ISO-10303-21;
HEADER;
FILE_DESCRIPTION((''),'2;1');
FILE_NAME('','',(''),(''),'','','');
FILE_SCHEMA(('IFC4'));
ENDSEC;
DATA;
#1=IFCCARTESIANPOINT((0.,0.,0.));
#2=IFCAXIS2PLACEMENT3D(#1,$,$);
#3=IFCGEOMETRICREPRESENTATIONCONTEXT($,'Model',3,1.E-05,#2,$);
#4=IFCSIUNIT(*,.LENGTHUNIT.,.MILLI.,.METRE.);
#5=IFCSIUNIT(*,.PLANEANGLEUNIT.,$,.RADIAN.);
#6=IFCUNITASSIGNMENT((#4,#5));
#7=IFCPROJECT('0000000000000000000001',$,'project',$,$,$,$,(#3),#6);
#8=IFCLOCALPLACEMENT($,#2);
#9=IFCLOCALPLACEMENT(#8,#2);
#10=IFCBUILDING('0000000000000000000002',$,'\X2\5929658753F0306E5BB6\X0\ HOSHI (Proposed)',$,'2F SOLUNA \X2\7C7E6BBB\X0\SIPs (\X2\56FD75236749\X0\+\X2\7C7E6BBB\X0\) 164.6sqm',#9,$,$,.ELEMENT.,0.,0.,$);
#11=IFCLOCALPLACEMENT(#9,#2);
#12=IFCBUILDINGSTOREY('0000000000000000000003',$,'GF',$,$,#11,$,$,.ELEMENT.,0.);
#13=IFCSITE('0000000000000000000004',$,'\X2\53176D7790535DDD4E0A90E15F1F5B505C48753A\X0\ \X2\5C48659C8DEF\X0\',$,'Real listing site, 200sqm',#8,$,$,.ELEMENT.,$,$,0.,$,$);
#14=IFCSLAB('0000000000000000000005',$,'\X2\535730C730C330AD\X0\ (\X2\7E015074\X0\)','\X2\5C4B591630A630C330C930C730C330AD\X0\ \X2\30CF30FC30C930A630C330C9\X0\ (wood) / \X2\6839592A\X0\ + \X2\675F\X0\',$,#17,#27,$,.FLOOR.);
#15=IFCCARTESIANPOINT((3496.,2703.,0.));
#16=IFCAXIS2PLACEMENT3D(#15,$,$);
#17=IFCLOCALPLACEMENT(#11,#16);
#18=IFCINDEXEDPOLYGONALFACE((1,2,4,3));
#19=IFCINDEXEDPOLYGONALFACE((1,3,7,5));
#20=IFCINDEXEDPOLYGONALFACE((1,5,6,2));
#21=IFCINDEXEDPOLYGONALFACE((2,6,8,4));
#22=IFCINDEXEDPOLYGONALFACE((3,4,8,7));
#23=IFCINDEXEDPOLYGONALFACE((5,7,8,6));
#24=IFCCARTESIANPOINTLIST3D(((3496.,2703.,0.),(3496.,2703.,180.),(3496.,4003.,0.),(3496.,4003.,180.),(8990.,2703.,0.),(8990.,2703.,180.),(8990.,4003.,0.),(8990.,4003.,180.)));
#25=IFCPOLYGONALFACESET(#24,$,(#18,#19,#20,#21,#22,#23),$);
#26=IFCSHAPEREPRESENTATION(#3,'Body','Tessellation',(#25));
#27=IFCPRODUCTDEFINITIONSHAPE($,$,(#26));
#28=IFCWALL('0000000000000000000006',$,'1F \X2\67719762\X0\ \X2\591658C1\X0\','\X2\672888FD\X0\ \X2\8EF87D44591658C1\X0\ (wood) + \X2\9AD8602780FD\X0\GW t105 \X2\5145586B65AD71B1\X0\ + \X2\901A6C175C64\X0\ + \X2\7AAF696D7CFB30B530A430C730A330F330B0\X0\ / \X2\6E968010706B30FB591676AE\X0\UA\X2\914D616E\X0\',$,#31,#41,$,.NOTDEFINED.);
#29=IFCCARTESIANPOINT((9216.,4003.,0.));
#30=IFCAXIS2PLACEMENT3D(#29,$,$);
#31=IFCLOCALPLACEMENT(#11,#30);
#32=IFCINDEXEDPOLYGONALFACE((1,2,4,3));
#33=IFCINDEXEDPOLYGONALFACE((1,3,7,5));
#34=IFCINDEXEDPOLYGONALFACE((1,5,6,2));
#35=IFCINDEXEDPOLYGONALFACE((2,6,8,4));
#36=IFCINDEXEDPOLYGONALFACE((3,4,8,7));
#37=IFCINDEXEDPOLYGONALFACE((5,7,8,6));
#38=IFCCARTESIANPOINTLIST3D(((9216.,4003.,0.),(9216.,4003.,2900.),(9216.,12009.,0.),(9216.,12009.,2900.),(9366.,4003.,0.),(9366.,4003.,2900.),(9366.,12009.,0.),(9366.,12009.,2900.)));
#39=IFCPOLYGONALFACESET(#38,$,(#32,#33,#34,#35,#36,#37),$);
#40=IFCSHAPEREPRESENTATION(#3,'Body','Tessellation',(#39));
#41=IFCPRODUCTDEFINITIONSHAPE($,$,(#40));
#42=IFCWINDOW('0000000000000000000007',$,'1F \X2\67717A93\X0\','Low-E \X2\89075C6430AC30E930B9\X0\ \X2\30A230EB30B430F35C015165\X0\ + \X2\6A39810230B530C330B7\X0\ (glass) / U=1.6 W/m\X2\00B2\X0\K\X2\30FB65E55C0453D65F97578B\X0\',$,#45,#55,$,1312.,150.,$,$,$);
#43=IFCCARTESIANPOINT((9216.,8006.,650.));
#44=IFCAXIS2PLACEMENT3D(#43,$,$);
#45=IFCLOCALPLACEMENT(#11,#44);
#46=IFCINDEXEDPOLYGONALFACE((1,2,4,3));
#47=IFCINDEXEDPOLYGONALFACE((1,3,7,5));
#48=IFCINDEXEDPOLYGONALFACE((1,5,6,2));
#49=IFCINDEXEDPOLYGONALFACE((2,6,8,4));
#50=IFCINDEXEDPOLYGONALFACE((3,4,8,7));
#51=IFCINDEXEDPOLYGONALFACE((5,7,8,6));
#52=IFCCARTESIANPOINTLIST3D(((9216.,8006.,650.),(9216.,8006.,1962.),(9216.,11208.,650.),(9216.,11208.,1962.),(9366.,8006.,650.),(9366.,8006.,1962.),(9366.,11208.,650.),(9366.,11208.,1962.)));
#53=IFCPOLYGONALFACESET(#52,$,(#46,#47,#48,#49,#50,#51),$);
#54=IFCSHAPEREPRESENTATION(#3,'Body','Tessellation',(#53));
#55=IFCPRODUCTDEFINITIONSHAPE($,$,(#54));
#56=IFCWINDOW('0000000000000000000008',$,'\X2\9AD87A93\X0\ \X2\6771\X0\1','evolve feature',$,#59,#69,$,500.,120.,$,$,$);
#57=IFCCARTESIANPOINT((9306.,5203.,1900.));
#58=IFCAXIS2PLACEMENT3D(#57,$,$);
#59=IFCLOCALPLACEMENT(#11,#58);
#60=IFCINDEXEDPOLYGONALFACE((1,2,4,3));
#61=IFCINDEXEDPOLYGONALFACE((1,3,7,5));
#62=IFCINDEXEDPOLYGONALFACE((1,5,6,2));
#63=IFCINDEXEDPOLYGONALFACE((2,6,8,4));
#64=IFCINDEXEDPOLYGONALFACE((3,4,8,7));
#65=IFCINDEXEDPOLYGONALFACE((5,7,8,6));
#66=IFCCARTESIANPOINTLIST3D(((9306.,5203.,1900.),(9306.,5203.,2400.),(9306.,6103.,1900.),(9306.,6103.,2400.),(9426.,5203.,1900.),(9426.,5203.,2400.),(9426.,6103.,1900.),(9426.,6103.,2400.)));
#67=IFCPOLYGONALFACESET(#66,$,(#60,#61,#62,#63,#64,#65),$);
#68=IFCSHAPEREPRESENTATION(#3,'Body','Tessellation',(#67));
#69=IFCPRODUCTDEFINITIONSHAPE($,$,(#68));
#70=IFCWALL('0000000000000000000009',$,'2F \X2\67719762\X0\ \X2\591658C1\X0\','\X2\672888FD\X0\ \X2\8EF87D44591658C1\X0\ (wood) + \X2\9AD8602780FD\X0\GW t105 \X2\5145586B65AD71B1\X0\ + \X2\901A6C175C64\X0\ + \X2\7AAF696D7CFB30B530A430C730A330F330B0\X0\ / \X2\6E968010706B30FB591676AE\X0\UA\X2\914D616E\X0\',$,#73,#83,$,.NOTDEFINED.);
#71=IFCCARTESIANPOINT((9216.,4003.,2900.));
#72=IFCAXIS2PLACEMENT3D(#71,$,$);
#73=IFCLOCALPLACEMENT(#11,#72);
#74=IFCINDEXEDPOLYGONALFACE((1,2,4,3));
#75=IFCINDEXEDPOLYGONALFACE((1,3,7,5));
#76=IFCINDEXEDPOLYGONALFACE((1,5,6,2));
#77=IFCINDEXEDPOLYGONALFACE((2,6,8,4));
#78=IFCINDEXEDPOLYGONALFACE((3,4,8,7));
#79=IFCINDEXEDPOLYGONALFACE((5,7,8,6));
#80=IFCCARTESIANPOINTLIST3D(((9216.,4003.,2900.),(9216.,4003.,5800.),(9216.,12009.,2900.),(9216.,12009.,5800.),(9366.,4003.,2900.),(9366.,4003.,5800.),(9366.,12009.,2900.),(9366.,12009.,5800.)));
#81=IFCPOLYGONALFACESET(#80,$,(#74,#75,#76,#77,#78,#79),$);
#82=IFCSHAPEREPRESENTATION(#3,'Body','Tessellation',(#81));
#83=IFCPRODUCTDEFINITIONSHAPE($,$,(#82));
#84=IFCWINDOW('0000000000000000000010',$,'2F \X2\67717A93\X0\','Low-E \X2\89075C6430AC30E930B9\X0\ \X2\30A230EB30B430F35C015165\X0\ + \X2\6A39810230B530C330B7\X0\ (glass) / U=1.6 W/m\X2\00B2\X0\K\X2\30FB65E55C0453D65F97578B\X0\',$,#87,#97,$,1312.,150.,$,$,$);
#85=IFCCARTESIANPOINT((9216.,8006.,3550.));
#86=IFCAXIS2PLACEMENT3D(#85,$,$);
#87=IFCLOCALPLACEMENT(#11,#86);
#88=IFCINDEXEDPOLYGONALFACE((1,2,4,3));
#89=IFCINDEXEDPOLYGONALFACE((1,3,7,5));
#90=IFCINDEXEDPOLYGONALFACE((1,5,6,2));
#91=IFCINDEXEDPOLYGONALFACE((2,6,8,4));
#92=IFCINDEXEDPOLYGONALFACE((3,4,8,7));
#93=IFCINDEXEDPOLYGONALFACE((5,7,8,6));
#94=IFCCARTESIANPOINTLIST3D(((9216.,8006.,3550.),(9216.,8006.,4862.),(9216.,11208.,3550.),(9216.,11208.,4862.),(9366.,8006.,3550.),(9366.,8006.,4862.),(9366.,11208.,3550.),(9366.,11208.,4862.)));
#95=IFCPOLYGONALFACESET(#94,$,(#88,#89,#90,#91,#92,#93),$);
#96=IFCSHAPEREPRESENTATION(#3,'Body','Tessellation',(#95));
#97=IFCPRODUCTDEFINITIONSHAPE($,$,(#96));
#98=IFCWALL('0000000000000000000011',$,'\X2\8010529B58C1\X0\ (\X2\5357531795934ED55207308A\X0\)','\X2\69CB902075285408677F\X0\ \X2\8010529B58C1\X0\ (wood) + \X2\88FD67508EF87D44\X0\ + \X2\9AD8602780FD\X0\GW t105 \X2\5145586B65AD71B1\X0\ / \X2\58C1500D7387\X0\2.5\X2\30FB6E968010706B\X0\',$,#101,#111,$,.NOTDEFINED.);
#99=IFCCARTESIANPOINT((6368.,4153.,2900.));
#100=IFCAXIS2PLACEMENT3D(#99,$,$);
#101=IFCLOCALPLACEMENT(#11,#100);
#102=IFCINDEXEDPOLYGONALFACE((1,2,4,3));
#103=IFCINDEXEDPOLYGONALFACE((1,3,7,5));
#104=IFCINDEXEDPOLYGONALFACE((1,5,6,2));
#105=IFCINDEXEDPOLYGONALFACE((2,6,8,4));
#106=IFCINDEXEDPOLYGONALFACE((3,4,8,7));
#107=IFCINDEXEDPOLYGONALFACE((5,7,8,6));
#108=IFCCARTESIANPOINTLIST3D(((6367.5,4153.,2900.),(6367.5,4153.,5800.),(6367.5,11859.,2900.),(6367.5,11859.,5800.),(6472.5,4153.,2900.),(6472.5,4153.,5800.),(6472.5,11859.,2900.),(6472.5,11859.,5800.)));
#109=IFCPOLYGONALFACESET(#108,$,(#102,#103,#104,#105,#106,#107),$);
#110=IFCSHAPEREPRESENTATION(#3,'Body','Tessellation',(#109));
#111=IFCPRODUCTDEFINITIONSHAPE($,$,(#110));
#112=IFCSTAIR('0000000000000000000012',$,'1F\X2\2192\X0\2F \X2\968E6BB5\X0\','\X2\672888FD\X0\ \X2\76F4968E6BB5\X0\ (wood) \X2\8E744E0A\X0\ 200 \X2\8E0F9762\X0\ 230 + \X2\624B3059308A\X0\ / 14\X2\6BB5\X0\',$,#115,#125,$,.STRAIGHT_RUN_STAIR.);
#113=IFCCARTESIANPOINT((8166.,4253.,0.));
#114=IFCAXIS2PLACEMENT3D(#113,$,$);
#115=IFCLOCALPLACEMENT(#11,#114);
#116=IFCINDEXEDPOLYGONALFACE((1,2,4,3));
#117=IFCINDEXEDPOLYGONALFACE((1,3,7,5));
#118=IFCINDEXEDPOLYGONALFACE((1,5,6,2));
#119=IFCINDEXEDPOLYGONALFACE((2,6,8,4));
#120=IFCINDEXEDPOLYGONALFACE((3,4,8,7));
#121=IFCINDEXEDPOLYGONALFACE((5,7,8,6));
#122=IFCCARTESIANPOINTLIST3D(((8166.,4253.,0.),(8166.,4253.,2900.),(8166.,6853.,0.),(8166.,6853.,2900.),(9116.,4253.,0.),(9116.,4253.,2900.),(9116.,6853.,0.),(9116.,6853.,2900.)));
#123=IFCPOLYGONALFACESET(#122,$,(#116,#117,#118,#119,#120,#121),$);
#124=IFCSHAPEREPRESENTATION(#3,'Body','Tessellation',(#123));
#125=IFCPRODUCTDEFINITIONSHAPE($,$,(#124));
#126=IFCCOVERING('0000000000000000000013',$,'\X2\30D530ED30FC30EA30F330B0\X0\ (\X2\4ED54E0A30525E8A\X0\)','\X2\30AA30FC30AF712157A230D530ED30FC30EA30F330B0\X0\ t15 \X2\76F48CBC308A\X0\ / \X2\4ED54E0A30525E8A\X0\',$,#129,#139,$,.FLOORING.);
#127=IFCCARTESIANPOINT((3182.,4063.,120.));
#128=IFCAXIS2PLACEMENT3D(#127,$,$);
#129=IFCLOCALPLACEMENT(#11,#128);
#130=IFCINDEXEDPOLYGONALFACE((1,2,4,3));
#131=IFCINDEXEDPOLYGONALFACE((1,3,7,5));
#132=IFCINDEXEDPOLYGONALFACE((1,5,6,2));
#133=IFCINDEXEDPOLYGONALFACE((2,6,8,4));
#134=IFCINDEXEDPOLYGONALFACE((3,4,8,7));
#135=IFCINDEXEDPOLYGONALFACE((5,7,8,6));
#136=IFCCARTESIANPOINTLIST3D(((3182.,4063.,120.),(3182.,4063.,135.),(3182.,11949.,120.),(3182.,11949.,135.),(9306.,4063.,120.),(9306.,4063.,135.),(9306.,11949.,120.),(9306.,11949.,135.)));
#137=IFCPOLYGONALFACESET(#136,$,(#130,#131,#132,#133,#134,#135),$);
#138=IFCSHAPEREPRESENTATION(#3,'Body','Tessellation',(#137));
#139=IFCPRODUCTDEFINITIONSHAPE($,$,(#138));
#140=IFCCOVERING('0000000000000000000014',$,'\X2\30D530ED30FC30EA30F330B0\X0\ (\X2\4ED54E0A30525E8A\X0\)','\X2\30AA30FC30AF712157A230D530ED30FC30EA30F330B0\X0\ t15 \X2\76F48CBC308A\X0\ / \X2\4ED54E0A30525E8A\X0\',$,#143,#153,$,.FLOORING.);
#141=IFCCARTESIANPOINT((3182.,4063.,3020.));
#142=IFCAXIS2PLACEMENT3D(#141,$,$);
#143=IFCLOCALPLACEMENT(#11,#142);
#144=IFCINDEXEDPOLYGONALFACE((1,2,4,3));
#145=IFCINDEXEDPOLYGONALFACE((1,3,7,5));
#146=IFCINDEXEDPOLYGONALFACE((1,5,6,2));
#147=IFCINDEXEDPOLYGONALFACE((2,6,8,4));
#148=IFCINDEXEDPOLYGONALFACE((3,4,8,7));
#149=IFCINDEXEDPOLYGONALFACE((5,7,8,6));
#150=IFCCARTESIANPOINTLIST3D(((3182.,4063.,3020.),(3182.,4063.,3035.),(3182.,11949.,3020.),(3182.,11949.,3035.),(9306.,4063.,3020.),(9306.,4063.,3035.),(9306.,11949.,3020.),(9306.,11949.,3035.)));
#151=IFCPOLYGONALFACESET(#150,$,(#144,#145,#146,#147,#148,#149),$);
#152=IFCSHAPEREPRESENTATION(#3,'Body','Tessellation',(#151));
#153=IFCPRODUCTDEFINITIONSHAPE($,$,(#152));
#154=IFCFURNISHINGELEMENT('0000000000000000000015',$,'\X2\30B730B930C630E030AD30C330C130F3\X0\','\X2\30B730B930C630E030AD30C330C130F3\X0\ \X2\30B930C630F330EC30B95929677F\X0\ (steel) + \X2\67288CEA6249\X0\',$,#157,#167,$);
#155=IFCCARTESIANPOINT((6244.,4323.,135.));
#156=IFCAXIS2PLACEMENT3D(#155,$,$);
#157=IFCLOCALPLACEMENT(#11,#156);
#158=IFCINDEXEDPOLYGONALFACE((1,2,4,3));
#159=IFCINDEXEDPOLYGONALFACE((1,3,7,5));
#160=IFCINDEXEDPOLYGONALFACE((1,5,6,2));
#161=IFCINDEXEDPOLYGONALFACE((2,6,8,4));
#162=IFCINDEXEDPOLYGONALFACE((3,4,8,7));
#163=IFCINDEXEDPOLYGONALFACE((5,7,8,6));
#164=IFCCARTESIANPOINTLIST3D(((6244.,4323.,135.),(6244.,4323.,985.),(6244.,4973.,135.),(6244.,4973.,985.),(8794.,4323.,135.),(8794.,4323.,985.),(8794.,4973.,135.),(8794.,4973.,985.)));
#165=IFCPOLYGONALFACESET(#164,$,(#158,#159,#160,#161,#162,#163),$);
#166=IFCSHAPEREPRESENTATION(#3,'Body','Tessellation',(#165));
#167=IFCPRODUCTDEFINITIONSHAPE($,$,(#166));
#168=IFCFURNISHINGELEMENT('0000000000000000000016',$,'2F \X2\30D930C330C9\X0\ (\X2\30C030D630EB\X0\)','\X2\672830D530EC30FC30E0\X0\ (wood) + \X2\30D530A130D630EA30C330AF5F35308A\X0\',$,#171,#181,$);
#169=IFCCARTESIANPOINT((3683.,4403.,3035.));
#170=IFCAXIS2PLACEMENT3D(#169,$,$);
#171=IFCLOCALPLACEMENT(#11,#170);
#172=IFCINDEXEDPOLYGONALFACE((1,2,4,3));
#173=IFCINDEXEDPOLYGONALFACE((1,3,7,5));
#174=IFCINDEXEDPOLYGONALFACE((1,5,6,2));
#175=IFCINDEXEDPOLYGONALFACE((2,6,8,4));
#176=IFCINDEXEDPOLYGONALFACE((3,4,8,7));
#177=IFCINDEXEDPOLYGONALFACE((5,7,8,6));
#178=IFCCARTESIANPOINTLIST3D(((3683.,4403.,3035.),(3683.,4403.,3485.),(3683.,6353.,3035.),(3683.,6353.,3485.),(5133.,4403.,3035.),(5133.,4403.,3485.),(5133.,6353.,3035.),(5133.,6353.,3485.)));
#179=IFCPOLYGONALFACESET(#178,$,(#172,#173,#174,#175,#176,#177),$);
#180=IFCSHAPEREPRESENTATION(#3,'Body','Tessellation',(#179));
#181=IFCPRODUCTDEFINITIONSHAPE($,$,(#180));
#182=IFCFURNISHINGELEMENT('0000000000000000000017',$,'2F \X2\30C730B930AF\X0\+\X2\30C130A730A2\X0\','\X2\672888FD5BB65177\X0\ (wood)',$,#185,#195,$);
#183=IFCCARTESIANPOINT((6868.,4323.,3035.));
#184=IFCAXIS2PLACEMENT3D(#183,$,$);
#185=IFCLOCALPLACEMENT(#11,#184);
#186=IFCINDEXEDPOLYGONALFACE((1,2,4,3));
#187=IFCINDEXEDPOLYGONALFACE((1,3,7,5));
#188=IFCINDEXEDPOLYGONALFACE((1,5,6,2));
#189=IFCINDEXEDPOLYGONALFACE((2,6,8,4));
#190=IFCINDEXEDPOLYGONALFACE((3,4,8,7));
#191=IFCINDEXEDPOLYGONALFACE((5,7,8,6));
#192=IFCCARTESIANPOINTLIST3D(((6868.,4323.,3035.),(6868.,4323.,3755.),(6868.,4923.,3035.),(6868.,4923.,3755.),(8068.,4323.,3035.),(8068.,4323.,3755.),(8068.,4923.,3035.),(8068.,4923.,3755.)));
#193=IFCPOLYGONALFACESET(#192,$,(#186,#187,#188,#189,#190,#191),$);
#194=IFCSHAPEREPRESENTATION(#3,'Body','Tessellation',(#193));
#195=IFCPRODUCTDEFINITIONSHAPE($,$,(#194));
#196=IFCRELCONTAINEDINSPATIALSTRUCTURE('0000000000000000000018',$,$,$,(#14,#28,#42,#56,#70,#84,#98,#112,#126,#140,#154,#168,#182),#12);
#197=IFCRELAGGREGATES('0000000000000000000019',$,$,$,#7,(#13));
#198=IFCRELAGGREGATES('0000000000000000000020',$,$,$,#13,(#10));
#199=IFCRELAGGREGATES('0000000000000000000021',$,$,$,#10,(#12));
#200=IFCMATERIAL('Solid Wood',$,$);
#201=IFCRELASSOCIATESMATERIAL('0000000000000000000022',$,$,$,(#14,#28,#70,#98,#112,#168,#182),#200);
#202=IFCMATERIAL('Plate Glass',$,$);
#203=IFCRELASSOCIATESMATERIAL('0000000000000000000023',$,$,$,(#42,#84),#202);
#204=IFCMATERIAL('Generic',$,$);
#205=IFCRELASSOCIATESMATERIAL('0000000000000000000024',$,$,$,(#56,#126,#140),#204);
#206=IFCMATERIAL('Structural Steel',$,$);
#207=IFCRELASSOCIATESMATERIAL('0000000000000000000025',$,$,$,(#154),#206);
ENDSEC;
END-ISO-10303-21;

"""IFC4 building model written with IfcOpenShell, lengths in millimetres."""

from ifc_helpers import new_model, si_unit, frame, frame_2d, origin, place, context, project, spatial, rectangle, extrude, material, element, fill, save


model = new_model("IFC4")

# Units and contexts
model_context = context("Model", 3, precision=1e-05, world=origin())
ifc_project = project(units=[si_unit("LENGTHUNIT", "METRE", prefix="MILLI"), si_unit("PLANEANGLEUNIT", "RADIAN")], contexts=[model_context])

# Site, building, storey
site_placement = place(None, origin())
site = spatial("IfcSite", under=ifc_project, at=site_placement, Name="北海道川上郡弟子屈町 屈斜路", ObjectType="Real listing site, 200sqm", CompositionType="ELEMENT", RefElevation=0.0)
building_placement = place(site_placement, origin())
building = spatial("IfcBuilding", under=site, at=building_placement, Name="天文台の家 HOSHI (Proposed)", ObjectType="2F SOLUNA 籾殻SIPs (国産杉+籾殻) 164.6sqm", CompositionType="ELEMENT", ElevationOfRefHeight=0.0, ElevationOfTerrain=0.0)
storey_placement = place(building_placement, origin())
storey = spatial("IfcBuildingStorey", under=building, at=storey_placement, Name="GF", CompositionType="ELEMENT", Elevation=0.0)

# Slab
ifc_material_1 = material(Name="Solid Wood")
slab_placement = place(storey_placement, frame((3496.0, 2703.0, 0.0)))
element("IfcSlab", 1, at=slab_placement, inside=storey, material=ifc_material_1, Name="南デッキ (縁側)", Description="屋外ウッドデッキ ハードウッド (wood) / 根太 + 束", PredefinedType="FLOOR", context=model_context, shape_type="SweptSolid", body=[
    extrude(rectangle(XDim=5494.0, YDim=1300.0, at=frame_2d((2747.0, 650.0))), frame((3496.0, 2703.0, 0.0)), (0.0, 0.0, 1.0), 180.0),
])

# Wall, openings, windows
wall_1_placement = place(storey_placement, frame((9216.0, 4003.0, 0.0)))
wall_1 = element("IfcWall", 2, at=wall_1_placement, inside=storey, material=ifc_material_1, Name="1F 東面 外壁", Description="木製 軸組外壁 (wood) + 高性能GW t105 充填断熱 + 通気層 + 窯業系サイディング / 準耐火・外皮UA配慮", PredefinedType="NOTDEFINED", context=model_context, shape_type="SweptSolid", body=[
    extrude(rectangle(XDim=150.0, YDim=8006.0, at=frame_2d((75.0, 4003.0))), frame((9216.0, 4003.0, 0.0)), (0.0, 0.0, 1.0), 2900.0),
])
opening_1_placement = place(storey_placement, frame((9216.0, 8006.0, 650.0)))
opening_1 = element("IfcOpeningElement", 3, at=opening_1_placement, cuts=wall_1, PredefinedType="NOTDEFINED", context=model_context, shape_type="SweptSolid", body=[
    extrude(rectangle(XDim=150.0, YDim=3202.0, at=frame_2d((75.0, 1601.0))), frame((9216.0, 8006.0, 650.0)), (0.0, 0.0, 1.0), 1312.0),
])
opening_2_placement = place(storey_placement, frame((9306.0, 5203.0, 1900.0)))
opening_2 = element("IfcOpeningElement", 4, at=opening_2_placement, cuts=wall_1, PredefinedType="NOTDEFINED", context=model_context, shape_type="SweptSolid", body=[
    extrude(rectangle(XDim=120.0, YDim=900.0, at=frame_2d((60.0, 450.0))), frame((9306.0, 5203.0, 1900.0)), (0.0, 0.0, 1.0), 500.0),
])
ifc_material_2 = material(Name="Plate Glass")
window_1_placement = place(storey_placement, frame((9216.0, 8006.0, 650.0)))
window_1 = element("IfcWindow", 5, at=window_1_placement, inside=storey, material=ifc_material_2, Name="1F 東窓", Description="Low-E 複層ガラス アルゴン封入 + 樹脂サッシ (glass) / U=1.6 W/m²K・日射取得型", OverallHeight=1312.0, OverallWidth=150.0, context=model_context, shape_type="SweptSolid", body=[
    extrude(rectangle(XDim=150.0, YDim=3202.0, at=frame_2d((75.0, 1601.0))), frame((9216.0, 8006.0, 650.0)), (0.0, 0.0, 1.0), 1312.0),
])
fill(opening_1, window_1)
ifc_material_3 = material(Name="Generic")
window_2_placement = place(storey_placement, frame((9306.0, 5203.0, 1900.0)))
window_2 = element("IfcWindow", 6, at=window_2_placement, inside=storey, material=ifc_material_3, Name="高窓 東1", Description="evolve feature", OverallHeight=500.0, OverallWidth=120.0, context=model_context, shape_type="SweptSolid", body=[
    extrude(rectangle(XDim=120.0, YDim=900.0, at=frame_2d((60.0, 450.0))), frame((9306.0, 5203.0, 1900.0)), (0.0, 0.0, 1.0), 500.0),
])
fill(opening_2, window_2)

# Wall, opening, window
wall_2_placement = place(storey_placement, frame((9216.0, 4003.0, 2900.0)))
wall_2 = element("IfcWall", 7, at=wall_2_placement, inside=storey, material=ifc_material_1, Name="2F 東面 外壁", Description="木製 軸組外壁 (wood) + 高性能GW t105 充填断熱 + 通気層 + 窯業系サイディング / 準耐火・外皮UA配慮", PredefinedType="NOTDEFINED", context=model_context, shape_type="SweptSolid", body=[
    extrude(rectangle(XDim=150.0, YDim=8006.0, at=frame_2d((75.0, 4003.0))), frame((9216.0, 4003.0, 2900.0)), (0.0, 0.0, 1.0), 2900.0),
])
opening_3_placement = place(storey_placement, frame((9216.0, 8006.0, 3550.0)))
opening_3 = element("IfcOpeningElement", 8, at=opening_3_placement, cuts=wall_2, PredefinedType="NOTDEFINED", context=model_context, shape_type="SweptSolid", body=[
    extrude(rectangle(XDim=150.0, YDim=3202.0, at=frame_2d((75.0, 1601.0))), frame((9216.0, 8006.0, 3550.0)), (0.0, 0.0, 1.0), 1312.0),
])
window_3_placement = place(storey_placement, frame((9216.0, 8006.0, 3550.0)))
window_3 = element("IfcWindow", 9, at=window_3_placement, inside=storey, material=ifc_material_2, Name="2F 東窓", Description="Low-E 複層ガラス アルゴン封入 + 樹脂サッシ (glass) / U=1.6 W/m²K・日射取得型", OverallHeight=1312.0, OverallWidth=150.0, context=model_context, shape_type="SweptSolid", body=[
    extrude(rectangle(XDim=150.0, YDim=3202.0, at=frame_2d((75.0, 1601.0))), frame((9216.0, 8006.0, 3550.0)), (0.0, 0.0, 1.0), 1312.0),
])
fill(opening_3, window_3)

# Wall
wall_3_placement = place(storey_placement, frame((6368.0, 4153.0, 2900.0)))
element("IfcWall", 10, at=wall_3_placement, inside=storey, material=ifc_material_1, Name="耐力壁 (南北間仕切り)", Description="構造用合板 耐力壁 (wood) + 製材軸組 + 高性能GW t105 充填断熱 / 壁倍率2.5・準耐火", PredefinedType="NOTDEFINED", context=model_context, shape_type="SweptSolid", body=[
    extrude(rectangle(XDim=105.0, YDim=7706.0, at=frame_2d((52.0, 3853.0))), frame((6368.0, 4153.0, 2900.0)), (0.0, 0.0, 1.0), 2900.0),
])

# Stair
stair_placement = place(storey_placement, frame((8166.0, 4253.0, 0.0)))
element("IfcStair", 11, at=stair_placement, inside=storey, material=ifc_material_1, Name="1F→2F 階段", Description="木製 直階段 (wood) 蹴上 200 踏面 230 + 手すり / 14段", PredefinedType="STRAIGHT_RUN_STAIR", context=model_context, shape_type="SweptSolid", body=[
    extrude(rectangle(XDim=950.0, YDim=2600.0, at=frame_2d((475.0, 1300.0))), frame((8166.0, 4253.0, 0.0)), (0.0, 0.0, 1.0), 2900.0),
])

# Coverings
covering_1_placement = place(storey_placement, frame((3182.0, 4063.0, 120.0)))
element("IfcCovering", 12, at=covering_1_placement, inside=storey, material=ifc_material_3, Name="フローリング (仕上げ床)", Description="オーク無垢フローリング t15 直貼り / 仕上げ床", PredefinedType="FLOORING", context=model_context, shape_type="SweptSolid", body=[
    extrude(rectangle(XDim=6124.0, YDim=7886.0, at=frame_2d((3062.0, 3943.0))), frame((3182.0, 4063.0, 120.0)), (0.0, 0.0, 1.0), 15.0),
])
covering_2_placement = place(storey_placement, frame((3182.0, 4063.0, 3020.0)))
element("IfcCovering", 13, at=covering_2_placement, inside=storey, material=ifc_material_3, Name="フローリング (仕上げ床)", Description="オーク無垢フローリング t15 直貼り / 仕上げ床", PredefinedType="FLOORING", context=model_context, shape_type="SweptSolid", body=[
    extrude(rectangle(XDim=6124.0, YDim=7886.0, at=frame_2d((3062.0, 3943.0))), frame((3182.0, 4063.0, 3020.0)), (0.0, 0.0, 1.0), 15.0),
])

# Furnishing elements
ifc_material_4 = material(Name="Structural Steel")
furnishing_1_placement = place(storey_placement, frame((6244.0, 4323.0, 135.0)))
element("IfcFurnishingElement", 14, at=furnishing_1_placement, inside=storey, material=ifc_material_4, Name="システムキッチン", Description="システムキッチン ステンレス天板 (steel) + 木質扉", context=model_context, shape_type="SweptSolid", body=[
    extrude(rectangle(XDim=2550.0, YDim=650.0, at=frame_2d((1275.0, 325.0))), frame((6244.0, 4323.0, 135.0)), (0.0, 0.0, 1.0), 850.0),
])
furnishing_2_placement = place(storey_placement, frame((3683.0, 4403.0, 3035.0)))
element("IfcFurnishingElement", 15, at=furnishing_2_placement, inside=storey, material=ifc_material_1, Name="2F ベッド (ダブル)", Description="木フレーム (wood) + ファブリック張り", context=model_context, shape_type="SweptSolid", body=[
    extrude(rectangle(XDim=1450.0, YDim=1950.0, at=frame_2d((725.0, 975.0))), frame((3683.0, 4403.0, 3035.0)), (0.0, 0.0, 1.0), 450.0),
])
furnishing_3_placement = place(storey_placement, frame((6868.0, 4323.0, 3035.0)))
element("IfcFurnishingElement", 16, at=furnishing_3_placement, inside=storey, material=ifc_material_1, Name="2F デスク+チェア", Description="木製家具 (wood)", context=model_context, shape_type="SweptSolid", body=[
    extrude(rectangle(XDim=1200.0, YDim=600.0, at=frame_2d((600.0, 300.0))), frame((6868.0, 4323.0, 3035.0)), (0.0, 0.0, 1.0), 720.0),
])

save(model, "model.ifc")
